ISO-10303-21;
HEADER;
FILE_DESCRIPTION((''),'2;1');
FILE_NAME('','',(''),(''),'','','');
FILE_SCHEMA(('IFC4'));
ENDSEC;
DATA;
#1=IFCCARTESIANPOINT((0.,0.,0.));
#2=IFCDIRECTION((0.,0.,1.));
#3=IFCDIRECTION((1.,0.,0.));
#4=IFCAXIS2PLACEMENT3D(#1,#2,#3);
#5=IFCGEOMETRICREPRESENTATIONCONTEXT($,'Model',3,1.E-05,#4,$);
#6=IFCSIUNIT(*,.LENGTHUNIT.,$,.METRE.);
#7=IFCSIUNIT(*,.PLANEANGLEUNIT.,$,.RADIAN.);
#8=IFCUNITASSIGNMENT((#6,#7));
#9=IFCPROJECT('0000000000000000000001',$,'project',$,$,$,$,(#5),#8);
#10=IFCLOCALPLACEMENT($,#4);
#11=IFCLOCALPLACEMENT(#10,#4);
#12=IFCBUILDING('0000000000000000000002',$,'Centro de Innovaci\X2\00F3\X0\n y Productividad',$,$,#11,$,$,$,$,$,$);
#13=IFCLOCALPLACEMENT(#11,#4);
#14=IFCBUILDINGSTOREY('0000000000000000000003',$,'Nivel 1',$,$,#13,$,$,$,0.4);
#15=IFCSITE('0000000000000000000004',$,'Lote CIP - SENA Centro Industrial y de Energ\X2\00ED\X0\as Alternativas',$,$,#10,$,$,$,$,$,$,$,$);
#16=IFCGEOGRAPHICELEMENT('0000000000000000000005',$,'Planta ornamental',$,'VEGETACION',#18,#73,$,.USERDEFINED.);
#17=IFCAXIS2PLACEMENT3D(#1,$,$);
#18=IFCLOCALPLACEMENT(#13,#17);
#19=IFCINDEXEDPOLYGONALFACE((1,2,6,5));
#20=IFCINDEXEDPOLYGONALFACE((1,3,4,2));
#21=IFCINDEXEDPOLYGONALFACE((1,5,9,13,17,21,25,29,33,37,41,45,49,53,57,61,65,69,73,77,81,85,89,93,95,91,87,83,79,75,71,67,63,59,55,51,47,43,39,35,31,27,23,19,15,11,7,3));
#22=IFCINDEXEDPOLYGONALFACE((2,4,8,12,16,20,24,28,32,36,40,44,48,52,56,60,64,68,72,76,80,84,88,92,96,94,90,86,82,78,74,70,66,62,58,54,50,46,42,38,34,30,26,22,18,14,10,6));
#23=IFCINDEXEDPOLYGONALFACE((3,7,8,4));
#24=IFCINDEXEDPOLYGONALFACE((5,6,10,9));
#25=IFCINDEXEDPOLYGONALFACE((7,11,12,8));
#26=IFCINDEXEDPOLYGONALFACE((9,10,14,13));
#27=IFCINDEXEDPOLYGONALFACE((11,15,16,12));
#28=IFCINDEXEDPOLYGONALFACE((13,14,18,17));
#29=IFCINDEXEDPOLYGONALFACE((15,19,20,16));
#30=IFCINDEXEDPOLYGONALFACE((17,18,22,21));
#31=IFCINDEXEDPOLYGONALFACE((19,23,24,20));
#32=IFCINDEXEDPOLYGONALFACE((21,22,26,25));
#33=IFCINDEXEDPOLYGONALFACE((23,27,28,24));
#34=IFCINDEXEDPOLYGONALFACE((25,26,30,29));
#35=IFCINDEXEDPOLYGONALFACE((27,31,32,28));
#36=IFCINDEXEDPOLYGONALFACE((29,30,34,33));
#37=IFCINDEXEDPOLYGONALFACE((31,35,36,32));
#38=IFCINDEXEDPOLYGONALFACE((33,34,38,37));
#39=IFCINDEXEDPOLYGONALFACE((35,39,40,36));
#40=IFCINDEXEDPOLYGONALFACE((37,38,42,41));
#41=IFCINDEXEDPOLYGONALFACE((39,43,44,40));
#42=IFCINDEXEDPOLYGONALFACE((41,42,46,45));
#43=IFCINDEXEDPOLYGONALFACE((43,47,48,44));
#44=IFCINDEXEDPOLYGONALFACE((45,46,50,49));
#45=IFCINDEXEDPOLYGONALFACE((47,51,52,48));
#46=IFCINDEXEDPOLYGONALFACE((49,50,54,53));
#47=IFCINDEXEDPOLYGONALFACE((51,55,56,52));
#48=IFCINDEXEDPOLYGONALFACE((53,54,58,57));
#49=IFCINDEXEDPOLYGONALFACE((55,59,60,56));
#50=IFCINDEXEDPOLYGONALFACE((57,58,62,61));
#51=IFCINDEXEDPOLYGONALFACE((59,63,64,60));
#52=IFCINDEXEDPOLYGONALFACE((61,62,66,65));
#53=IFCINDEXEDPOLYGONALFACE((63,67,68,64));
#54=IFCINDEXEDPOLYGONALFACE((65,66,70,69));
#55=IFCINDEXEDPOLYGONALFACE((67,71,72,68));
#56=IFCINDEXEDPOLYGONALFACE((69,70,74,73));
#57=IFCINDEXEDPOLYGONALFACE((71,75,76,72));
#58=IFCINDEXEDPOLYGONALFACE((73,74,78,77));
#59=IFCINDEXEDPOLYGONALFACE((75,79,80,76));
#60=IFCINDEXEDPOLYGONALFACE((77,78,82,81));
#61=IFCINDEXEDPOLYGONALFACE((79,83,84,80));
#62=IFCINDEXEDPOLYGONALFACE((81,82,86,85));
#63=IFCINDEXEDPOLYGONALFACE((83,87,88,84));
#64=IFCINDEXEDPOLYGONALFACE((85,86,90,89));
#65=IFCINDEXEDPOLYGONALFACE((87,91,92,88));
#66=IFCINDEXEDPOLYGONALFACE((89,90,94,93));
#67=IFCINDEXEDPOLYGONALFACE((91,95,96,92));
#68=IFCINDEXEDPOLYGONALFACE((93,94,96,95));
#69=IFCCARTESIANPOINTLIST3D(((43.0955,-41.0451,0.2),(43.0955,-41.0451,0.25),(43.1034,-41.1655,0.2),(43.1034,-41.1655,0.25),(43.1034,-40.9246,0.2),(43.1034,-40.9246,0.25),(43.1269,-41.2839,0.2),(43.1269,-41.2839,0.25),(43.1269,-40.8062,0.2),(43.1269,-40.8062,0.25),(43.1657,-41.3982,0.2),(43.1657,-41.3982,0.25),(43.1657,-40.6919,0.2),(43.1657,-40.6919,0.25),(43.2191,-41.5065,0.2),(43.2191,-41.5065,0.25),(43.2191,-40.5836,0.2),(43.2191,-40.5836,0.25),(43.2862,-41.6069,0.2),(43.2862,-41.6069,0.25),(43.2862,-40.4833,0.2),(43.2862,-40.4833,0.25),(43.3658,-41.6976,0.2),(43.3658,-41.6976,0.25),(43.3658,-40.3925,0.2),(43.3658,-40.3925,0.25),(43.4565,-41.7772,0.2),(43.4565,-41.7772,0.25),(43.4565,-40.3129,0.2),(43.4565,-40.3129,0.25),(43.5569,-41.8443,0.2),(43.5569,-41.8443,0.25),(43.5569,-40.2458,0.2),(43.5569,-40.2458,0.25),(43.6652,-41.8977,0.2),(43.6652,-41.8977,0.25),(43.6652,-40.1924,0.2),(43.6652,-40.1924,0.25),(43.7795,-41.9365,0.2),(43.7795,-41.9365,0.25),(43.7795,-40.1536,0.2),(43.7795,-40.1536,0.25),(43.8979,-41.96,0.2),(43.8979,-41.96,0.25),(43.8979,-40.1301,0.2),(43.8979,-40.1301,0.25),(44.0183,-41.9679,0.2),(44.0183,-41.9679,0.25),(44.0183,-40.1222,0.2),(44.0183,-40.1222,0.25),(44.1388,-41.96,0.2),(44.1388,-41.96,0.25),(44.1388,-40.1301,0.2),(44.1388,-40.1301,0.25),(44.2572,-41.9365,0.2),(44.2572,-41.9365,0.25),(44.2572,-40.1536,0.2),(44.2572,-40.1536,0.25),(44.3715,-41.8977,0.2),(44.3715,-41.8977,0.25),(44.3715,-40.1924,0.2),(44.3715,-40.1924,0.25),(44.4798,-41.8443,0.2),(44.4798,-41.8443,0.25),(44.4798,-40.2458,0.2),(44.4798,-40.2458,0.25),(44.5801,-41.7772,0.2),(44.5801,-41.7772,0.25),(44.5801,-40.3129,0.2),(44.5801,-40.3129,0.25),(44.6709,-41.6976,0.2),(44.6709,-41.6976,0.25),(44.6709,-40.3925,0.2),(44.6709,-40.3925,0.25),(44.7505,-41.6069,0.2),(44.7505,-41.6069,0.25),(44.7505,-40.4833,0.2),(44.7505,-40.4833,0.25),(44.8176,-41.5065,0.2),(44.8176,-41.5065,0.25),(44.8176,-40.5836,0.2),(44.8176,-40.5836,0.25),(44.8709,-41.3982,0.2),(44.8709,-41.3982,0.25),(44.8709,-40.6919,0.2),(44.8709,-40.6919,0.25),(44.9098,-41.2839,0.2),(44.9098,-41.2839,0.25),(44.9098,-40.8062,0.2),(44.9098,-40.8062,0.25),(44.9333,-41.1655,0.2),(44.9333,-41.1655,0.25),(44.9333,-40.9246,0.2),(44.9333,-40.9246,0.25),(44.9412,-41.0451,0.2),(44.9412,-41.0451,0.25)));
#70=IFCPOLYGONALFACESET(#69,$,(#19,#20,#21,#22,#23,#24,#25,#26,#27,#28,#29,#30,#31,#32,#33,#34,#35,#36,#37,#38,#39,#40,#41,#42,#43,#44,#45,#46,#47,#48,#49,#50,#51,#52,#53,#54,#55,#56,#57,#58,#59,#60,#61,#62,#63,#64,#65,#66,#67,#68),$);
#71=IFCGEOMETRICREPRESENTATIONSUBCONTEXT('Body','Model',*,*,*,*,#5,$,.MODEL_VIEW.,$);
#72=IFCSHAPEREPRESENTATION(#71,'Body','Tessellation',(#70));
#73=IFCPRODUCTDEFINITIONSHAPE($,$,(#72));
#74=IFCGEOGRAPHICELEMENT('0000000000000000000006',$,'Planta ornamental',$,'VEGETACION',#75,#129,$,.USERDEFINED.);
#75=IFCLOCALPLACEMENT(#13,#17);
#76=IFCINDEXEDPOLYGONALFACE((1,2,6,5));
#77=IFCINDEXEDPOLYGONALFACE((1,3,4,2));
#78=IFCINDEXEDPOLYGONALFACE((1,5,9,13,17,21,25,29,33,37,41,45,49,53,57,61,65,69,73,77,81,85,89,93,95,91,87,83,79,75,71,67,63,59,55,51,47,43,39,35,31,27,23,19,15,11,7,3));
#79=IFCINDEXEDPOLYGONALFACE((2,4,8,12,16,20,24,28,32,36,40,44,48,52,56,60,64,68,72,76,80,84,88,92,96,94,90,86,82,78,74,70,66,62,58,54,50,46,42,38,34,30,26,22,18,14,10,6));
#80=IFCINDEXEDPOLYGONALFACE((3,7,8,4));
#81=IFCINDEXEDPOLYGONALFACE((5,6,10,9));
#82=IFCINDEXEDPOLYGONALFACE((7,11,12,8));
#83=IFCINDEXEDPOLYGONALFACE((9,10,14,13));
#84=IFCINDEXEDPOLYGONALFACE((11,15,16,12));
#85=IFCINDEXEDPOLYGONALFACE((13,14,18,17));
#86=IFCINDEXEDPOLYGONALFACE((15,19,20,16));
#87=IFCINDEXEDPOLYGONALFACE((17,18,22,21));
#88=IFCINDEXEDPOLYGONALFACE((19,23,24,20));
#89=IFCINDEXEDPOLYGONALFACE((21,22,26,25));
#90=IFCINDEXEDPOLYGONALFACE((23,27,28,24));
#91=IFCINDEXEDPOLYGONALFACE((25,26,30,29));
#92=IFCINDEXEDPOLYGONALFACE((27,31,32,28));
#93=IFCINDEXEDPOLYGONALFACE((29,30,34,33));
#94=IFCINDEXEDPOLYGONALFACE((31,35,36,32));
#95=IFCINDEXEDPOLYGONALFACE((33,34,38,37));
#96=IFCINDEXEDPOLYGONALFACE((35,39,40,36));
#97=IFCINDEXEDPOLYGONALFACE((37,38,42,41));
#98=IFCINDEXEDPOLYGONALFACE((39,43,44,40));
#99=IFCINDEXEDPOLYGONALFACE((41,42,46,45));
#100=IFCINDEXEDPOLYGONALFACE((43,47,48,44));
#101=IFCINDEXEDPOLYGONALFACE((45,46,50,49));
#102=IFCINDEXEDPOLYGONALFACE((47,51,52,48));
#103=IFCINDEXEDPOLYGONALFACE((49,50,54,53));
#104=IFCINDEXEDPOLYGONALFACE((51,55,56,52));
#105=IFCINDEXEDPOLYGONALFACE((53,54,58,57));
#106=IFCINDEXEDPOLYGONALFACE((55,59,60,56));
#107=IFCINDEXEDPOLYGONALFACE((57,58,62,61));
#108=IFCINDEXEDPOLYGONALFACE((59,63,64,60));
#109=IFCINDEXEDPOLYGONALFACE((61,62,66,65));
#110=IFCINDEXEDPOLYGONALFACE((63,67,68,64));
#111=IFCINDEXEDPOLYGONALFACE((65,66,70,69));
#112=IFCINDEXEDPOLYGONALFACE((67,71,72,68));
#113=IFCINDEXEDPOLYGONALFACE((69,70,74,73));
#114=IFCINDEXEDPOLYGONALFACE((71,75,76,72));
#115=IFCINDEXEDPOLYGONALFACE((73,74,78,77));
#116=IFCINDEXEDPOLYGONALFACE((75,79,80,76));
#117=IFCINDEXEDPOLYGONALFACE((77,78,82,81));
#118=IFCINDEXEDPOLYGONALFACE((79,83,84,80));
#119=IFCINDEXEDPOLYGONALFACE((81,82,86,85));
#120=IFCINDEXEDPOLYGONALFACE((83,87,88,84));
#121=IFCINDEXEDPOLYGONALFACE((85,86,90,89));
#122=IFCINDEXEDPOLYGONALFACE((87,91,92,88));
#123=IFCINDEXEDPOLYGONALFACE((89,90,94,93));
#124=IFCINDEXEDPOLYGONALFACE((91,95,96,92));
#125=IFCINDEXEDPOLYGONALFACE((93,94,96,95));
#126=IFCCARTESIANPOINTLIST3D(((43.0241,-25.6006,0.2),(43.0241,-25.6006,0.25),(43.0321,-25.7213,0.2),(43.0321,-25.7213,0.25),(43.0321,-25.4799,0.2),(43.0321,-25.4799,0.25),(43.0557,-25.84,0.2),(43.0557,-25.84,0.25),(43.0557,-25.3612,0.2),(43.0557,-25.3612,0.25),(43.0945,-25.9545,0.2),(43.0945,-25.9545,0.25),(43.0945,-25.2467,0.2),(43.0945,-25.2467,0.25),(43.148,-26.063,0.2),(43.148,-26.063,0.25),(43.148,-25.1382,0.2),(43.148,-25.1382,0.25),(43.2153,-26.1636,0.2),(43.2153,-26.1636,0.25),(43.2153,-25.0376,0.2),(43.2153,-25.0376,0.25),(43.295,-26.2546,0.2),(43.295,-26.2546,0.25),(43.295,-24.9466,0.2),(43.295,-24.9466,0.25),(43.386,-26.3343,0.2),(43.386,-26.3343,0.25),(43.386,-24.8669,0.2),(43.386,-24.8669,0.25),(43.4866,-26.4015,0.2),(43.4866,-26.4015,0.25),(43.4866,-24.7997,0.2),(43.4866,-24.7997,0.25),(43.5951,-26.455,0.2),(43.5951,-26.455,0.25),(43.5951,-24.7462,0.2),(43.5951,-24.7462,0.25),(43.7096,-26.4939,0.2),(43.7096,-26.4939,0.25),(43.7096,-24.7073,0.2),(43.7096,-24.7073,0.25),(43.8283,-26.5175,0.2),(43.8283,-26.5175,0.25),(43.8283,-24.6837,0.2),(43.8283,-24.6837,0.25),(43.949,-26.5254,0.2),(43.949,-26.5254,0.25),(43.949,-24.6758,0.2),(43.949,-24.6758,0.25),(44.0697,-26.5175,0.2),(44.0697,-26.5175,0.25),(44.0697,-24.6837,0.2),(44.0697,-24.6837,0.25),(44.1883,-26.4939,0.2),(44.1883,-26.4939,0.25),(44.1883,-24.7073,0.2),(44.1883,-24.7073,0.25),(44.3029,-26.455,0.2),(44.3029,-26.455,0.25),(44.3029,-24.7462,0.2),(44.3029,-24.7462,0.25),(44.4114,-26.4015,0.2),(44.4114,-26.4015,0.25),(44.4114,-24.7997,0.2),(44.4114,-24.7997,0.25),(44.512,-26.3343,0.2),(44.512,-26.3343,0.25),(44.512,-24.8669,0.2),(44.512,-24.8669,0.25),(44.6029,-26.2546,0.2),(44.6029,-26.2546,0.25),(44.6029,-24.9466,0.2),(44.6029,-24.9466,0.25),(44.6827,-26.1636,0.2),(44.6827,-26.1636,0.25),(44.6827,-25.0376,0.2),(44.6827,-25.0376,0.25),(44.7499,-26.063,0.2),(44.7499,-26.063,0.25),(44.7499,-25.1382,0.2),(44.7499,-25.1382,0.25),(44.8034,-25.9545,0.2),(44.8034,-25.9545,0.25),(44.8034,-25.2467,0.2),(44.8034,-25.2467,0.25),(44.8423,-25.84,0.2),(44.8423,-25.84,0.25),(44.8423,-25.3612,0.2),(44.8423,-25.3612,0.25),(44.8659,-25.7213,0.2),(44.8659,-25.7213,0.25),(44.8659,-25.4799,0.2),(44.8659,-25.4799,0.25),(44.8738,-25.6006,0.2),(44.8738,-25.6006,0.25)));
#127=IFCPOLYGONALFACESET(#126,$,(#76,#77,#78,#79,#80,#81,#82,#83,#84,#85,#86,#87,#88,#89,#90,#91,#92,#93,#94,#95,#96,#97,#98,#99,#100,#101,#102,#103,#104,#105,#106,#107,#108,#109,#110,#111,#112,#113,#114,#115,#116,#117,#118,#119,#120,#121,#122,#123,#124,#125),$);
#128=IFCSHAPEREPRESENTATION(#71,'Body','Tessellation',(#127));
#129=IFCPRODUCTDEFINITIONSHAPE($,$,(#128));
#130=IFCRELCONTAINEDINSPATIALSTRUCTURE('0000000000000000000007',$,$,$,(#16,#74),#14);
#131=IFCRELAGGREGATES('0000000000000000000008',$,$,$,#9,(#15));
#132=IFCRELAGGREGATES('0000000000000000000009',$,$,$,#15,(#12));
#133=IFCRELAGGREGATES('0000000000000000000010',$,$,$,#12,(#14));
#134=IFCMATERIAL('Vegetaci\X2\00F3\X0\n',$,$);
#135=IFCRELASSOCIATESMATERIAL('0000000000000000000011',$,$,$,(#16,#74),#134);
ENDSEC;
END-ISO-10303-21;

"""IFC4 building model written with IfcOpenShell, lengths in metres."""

from ifc_helpers import new_model, si_unit, frame, origin_with_axes, place, context, subcontext, project, spatial, polyline, outline, extrude, material, element, save


model = new_model("IFC4")

# Units and contexts
model_context = context("Model", 3, precision=1e-05, world=origin_with_axes())
body_context = subcontext(model_context, "Body", "Model", "MODEL_VIEW")
ifc_project = project(units=[si_unit("LENGTHUNIT", "METRE"), si_unit("PLANEANGLEUNIT", "RADIAN")], contexts=[model_context])

# Site, building, storey
site_placement = place(None, origin_with_axes())
site = spatial("IfcSite", under=ifc_project, at=site_placement, Name="Lote CIP - SENA Centro Industrial y de Energías Alternativas")
building_placement = place(site_placement, origin_with_axes())
building = spatial("IfcBuilding", under=site, at=building_placement, Name="Centro de Innovación y Productividad")
storey_placement = place(building_placement, origin_with_axes())
storey = spatial("IfcBuildingStorey", under=building, at=storey_placement, Name="Nivel 1", Elevation=0.4)

# Geographic elements
ifc_material = material(Name="Vegetación")
geographic_element_1_placement = place(storey_placement, origin_with_axes())
element("IfcGeographicElement", 1, at=geographic_element_1_placement, inside=storey, material=ifc_material, Name="Planta ornamental", ObjectType="VEGETACION", PredefinedType="USERDEFINED", context=body_context, shape_type="SweptSolid", body=[
    extrude(outline(polyline([(44.9412, -41.0451), (44.9333, -41.1655), (44.9098, -41.2839), (44.8709, -41.3982), (44.8176, -41.5065), (44.7505, -41.6069), (44.6709, -41.6976), (44.5801, -41.7772), (44.4798, -41.8443), (44.3715, -41.8977), (44.2572, -41.9365), (44.1388, -41.96), (44.0183, -41.9679), (43.8979, -41.96), (43.7795, -41.9365), (43.6652, -41.8977), (43.5569, -41.8443), (43.4565, -41.7772), (43.3658, -41.6976), (43.2862, -41.6069), (43.2191, -41.5065), (43.1657, -41.3982), (43.1269, -41.2839), (43.1034, -41.1655), (43.0955, -41.0451), (43.1034, -40.9246), (43.1269, -40.8062), (43.1657, -40.6919), (43.2191, -40.5836), (43.2862, -40.4833), (43.3658, -40.3925), (43.4565, -40.3129), (43.5569, -40.2458), (43.6652, -40.1924), (43.7795, -40.1536), (43.8979, -40.1301), (44.0183, -40.1222), (44.1388, -40.1301), (44.2572, -40.1536), (44.3715, -40.1924), (44.4798, -40.2458), (44.5801, -40.3129), (44.6709, -40.3925), (44.7505, -40.4833), (44.8176, -40.5836), (44.8709, -40.6919), (44.9098, -40.8062), (44.9333, -40.9246), (44.9412, -41.0451)])), frame((0.0, 0.0, 0.2)), (0.0, 0.0, 1.0), 0.05),
])
geographic_element_2_placement = place(storey_placement, origin_with_axes())
element("IfcGeographicElement", 2, at=geographic_element_2_placement, inside=storey, material=ifc_material, Name="Planta ornamental", ObjectType="VEGETACION", PredefinedType="USERDEFINED", context=body_context, shape_type="SweptSolid", body=[
    extrude(outline(polyline([(44.8738, -25.6006), (44.8659, -25.7213), (44.8423, -25.84), (44.8034, -25.9545), (44.7499, -26.063), (44.6827, -26.1636), (44.6029, -26.2546), (44.512, -26.3343), (44.4114, -26.4015), (44.3029, -26.455), (44.1883, -26.4939), (44.0697, -26.5175), (43.949, -26.5254), (43.8283, -26.5175), (43.7096, -26.4939), (43.5951, -26.455), (43.4866, -26.4015), (43.386, -26.3343), (43.295, -26.2546), (43.2153, -26.1636), (43.148, -26.063), (43.0945, -25.9545), (43.0557, -25.84), (43.0321, -25.7213), (43.0241, -25.6006), (43.0321, -25.4799), (43.0557, -25.3612), (43.0945, -25.2467), (43.148, -25.1382), (43.2153, -25.0376), (43.295, -24.9466), (43.386, -24.8669), (43.4866, -24.7997), (43.5951, -24.7462), (43.7096, -24.7073), (43.8283, -24.6837), (43.949, -24.6758), (44.0697, -24.6837), (44.1883, -24.7073), (44.3029, -24.7462), (44.4114, -24.7997), (44.512, -24.8669), (44.6029, -24.9466), (44.6827, -25.0376), (44.7499, -25.1382), (44.8034, -25.2467), (44.8423, -25.3612), (44.8659, -25.4799), (44.8738, -25.6006)])), frame((0.0, 0.0, 0.2)), (0.0, 0.0, 1.0), 0.05),
])

save(model, "model.ifc")
